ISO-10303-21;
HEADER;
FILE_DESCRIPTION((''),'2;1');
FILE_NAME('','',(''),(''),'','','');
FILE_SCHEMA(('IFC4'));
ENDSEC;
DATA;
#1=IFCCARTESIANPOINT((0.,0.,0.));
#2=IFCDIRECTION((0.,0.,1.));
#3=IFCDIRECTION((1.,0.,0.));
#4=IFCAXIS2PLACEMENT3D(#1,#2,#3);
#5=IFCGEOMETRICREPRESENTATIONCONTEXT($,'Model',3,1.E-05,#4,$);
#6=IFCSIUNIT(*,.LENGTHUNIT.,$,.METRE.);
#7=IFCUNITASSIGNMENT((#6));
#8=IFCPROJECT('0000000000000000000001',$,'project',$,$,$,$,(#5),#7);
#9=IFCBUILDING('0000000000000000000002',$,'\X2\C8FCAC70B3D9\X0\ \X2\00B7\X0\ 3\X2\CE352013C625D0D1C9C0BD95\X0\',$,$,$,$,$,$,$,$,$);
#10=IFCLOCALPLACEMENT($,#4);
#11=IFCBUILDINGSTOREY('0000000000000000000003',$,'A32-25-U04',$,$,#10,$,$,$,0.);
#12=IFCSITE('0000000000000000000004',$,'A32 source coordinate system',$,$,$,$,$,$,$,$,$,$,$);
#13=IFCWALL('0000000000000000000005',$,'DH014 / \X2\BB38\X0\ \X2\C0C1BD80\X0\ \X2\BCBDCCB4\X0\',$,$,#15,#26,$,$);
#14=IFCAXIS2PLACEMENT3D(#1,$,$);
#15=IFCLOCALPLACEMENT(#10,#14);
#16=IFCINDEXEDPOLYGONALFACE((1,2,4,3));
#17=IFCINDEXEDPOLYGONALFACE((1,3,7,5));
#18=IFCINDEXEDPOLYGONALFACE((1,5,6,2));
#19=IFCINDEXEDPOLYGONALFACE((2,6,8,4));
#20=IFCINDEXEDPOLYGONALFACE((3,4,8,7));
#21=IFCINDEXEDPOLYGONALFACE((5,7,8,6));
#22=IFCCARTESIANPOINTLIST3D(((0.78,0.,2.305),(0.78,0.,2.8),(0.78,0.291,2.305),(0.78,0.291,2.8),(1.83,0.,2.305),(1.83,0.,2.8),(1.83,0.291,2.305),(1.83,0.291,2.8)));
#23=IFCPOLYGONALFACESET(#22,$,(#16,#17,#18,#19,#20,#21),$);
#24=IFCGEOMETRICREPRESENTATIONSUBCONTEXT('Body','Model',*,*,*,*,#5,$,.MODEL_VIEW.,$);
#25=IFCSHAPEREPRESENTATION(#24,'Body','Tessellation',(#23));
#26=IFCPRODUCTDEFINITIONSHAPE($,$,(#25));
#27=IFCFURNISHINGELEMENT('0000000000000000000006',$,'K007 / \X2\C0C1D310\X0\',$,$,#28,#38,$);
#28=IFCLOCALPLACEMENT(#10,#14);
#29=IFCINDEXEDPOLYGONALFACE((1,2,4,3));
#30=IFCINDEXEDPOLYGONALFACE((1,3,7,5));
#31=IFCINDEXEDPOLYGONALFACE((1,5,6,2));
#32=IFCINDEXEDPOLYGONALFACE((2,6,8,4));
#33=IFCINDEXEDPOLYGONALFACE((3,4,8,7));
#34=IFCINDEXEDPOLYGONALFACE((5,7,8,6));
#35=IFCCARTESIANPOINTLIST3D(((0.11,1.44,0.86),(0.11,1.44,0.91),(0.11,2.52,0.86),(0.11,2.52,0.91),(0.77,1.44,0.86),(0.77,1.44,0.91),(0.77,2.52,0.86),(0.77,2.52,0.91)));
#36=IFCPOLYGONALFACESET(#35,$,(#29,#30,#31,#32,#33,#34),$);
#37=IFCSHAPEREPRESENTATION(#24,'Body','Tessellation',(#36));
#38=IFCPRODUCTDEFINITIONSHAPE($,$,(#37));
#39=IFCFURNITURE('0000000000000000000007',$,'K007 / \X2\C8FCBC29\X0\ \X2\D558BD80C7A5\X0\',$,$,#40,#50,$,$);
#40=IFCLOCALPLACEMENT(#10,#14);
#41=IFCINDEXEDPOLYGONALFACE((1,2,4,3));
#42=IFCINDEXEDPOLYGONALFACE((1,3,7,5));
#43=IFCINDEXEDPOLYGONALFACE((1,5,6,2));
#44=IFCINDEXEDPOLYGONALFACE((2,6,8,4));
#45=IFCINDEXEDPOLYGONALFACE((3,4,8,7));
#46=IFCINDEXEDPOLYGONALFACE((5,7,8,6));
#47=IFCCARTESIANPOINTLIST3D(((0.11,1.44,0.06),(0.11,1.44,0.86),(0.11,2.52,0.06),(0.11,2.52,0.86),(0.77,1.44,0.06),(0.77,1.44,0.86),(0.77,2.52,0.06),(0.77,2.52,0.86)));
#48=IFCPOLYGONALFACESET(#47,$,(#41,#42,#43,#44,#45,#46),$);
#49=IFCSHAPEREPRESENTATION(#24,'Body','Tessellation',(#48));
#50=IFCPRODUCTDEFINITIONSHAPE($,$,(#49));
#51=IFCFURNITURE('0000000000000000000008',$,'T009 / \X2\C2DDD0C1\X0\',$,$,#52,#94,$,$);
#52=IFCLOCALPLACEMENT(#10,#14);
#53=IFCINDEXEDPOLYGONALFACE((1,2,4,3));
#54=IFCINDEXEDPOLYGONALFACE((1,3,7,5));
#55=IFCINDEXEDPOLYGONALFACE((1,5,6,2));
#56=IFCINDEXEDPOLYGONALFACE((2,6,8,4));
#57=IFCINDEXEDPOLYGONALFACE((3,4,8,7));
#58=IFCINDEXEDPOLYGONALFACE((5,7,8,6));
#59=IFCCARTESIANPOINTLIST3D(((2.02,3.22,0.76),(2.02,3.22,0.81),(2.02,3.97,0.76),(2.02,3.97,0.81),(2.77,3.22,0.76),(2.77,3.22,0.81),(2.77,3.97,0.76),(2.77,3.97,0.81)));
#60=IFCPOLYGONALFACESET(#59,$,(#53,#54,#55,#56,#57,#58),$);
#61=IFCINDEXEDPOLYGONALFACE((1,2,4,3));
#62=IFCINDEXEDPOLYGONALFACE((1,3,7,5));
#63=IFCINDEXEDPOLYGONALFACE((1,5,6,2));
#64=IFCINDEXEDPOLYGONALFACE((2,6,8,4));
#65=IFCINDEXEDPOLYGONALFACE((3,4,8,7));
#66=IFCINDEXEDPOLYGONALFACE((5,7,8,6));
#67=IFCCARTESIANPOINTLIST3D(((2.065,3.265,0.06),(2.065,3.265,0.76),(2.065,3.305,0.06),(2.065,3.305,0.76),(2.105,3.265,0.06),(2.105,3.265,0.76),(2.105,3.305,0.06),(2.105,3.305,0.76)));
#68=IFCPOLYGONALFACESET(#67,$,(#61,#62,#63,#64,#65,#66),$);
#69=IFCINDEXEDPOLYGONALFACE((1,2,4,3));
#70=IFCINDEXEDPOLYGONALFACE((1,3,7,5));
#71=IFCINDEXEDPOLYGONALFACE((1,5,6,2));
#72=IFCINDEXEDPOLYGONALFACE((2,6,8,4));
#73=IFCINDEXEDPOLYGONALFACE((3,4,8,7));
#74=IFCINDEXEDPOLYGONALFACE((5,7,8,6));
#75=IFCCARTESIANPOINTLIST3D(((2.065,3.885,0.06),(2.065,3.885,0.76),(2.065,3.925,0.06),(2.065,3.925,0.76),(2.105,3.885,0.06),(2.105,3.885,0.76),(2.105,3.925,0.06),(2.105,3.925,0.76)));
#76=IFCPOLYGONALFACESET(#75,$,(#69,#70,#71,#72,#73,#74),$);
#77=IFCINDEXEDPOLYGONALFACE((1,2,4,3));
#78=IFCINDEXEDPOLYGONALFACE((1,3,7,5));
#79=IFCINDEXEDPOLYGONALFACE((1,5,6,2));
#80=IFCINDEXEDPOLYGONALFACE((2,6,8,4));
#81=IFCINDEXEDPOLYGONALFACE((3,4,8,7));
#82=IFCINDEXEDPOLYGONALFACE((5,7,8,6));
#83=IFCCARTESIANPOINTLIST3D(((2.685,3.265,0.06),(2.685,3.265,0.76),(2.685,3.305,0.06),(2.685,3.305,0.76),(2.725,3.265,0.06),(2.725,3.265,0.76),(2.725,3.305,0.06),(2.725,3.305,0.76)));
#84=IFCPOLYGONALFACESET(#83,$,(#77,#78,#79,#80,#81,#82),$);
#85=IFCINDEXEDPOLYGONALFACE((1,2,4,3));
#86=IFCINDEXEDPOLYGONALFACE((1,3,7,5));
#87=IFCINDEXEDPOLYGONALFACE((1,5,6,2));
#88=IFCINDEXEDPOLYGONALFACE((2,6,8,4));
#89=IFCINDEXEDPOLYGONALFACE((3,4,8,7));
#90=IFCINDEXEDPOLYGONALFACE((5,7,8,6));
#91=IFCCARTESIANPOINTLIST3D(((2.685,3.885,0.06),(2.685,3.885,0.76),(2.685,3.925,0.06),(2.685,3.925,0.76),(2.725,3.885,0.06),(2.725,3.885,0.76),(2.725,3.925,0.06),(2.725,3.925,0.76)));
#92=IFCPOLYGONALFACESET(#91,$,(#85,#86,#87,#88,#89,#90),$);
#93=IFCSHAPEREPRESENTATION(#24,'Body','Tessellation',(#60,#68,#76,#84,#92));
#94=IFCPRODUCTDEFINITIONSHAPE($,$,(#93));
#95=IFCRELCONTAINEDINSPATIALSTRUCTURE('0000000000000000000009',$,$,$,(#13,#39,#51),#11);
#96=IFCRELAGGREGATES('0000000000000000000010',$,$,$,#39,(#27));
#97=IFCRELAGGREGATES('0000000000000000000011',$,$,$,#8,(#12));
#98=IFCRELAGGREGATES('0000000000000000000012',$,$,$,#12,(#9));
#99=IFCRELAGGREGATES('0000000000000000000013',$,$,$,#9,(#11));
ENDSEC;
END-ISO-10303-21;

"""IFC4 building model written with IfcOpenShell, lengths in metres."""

from ifc_helpers import new_model, si_unit, frame, origin_with_axes, place, context, subcontext, project, spatial, polyline, outline, extrude, element, aggregate, save


model = new_model("IFC4")

# Units and contexts
model_context = context("Model", 3, precision=1e-05, world=origin_with_axes())
body_context = subcontext(model_context, "Body", "Model", "MODEL_VIEW")
ifc_project = project(units=[si_unit("LENGTHUNIT", "METRE")], contexts=[model_context])

# Site, building, storey
site = spatial("IfcSite", under=ifc_project, Name="A32 source coordinate system")
building = spatial("IfcBuilding", under=site, Name="주거동 · 3층–옥탑지붕")
storey_placement = place(None, origin_with_axes())
storey = spatial("IfcBuildingStorey", under=building, at=storey_placement, Name="A32-25-U04", Elevation=0.0)

# Wall
wall_1_placement = place(storey_placement, origin_with_axes())
element("IfcWall", 1, at=wall_1_placement, inside=storey, Name="DH014 / 문 상부 벽체", context=body_context, shape_type="SweptSolid", body=[
    extrude(outline(polyline([(0.78, 0.291), (1.83, 0.291), (1.83, 0.0), (0.78, 0.0), (0.78, 0.291)])), frame((0.0, 0.0, 2.305)), (0.0, 0.0, 1.0), 0.495),
])

# Furnishing element
furniture_1_placement = place(storey_placement, origin_with_axes())
furnishing_1_placement = place(furniture_1_placement, origin_with_axes())
furnishing_1 = element("IfcFurnishingElement", 2, at=furnishing_1_placement, Name="K007 / 상판", context=body_context, shape_type="SweptSolid", body=[
    extrude(outline(polyline([(0.77, 2.52), (0.77, 1.44), (0.11, 1.44), (0.11, 2.52), (0.77, 2.52)])), frame((0.0, 0.0, 0.86)), (0.0, 0.0, 1.0), 0.05),
])

# Furniture
furniture_1 = element("IfcFurniture", 3, at=furniture_1_placement, inside=storey, Name="K007 / 주방 하부장", context=body_context, shape_type="SweptSolid", body=[
    extrude(outline(polyline([(0.11, 2.52), (0.77, 2.52), (0.77, 1.44), (0.11, 1.44), (0.11, 2.52)])), frame((0.0, 0.0, 0.06)), (0.0, 0.0, 1.0), 0.8),
])
aggregate(furniture_1, [furnishing_1])
furniture_2_placement = place(storey_placement, origin_with_axes())
element("IfcFurniture", 4, at=furniture_2_placement, inside=storey, Name="T009 / 식탁", context=body_context, shape_type="SweptSolid", body=[
    extrude(outline(polyline([(2.77, 3.22), (2.02, 3.22), (2.02, 3.97), (2.77, 3.97), (2.77, 3.22)])), frame((0.0, 0.0, 0.76)), (0.0, 0.0, 1.0), 0.05),
    extrude(outline(polyline([(2.065, 3.265), (2.065, 3.305), (2.105, 3.305), (2.105, 3.265), (2.065, 3.265)])), frame((0.0, 0.0, 0.06)), (0.0, 0.0, 1.0), 0.7),
    extrude(outline(polyline([(2.065, 3.885), (2.065, 3.925), (2.105, 3.925), (2.105, 3.885), (2.065, 3.885)])), frame((0.0, 0.0, 0.06)), (0.0, 0.0, 1.0), 0.7),
    extrude(outline(polyline([(2.685, 3.265), (2.685, 3.305), (2.725, 3.305), (2.725, 3.265), (2.685, 3.265)])), frame((0.0, 0.0, 0.06)), (0.0, 0.0, 1.0), 0.7),
    extrude(outline(polyline([(2.685, 3.885), (2.685, 3.925), (2.725, 3.925), (2.725, 3.885), (2.685, 3.885)])), frame((0.0, 0.0, 0.06)), (0.0, 0.0, 1.0), 0.7),
])

save(model, "model.ifc")
